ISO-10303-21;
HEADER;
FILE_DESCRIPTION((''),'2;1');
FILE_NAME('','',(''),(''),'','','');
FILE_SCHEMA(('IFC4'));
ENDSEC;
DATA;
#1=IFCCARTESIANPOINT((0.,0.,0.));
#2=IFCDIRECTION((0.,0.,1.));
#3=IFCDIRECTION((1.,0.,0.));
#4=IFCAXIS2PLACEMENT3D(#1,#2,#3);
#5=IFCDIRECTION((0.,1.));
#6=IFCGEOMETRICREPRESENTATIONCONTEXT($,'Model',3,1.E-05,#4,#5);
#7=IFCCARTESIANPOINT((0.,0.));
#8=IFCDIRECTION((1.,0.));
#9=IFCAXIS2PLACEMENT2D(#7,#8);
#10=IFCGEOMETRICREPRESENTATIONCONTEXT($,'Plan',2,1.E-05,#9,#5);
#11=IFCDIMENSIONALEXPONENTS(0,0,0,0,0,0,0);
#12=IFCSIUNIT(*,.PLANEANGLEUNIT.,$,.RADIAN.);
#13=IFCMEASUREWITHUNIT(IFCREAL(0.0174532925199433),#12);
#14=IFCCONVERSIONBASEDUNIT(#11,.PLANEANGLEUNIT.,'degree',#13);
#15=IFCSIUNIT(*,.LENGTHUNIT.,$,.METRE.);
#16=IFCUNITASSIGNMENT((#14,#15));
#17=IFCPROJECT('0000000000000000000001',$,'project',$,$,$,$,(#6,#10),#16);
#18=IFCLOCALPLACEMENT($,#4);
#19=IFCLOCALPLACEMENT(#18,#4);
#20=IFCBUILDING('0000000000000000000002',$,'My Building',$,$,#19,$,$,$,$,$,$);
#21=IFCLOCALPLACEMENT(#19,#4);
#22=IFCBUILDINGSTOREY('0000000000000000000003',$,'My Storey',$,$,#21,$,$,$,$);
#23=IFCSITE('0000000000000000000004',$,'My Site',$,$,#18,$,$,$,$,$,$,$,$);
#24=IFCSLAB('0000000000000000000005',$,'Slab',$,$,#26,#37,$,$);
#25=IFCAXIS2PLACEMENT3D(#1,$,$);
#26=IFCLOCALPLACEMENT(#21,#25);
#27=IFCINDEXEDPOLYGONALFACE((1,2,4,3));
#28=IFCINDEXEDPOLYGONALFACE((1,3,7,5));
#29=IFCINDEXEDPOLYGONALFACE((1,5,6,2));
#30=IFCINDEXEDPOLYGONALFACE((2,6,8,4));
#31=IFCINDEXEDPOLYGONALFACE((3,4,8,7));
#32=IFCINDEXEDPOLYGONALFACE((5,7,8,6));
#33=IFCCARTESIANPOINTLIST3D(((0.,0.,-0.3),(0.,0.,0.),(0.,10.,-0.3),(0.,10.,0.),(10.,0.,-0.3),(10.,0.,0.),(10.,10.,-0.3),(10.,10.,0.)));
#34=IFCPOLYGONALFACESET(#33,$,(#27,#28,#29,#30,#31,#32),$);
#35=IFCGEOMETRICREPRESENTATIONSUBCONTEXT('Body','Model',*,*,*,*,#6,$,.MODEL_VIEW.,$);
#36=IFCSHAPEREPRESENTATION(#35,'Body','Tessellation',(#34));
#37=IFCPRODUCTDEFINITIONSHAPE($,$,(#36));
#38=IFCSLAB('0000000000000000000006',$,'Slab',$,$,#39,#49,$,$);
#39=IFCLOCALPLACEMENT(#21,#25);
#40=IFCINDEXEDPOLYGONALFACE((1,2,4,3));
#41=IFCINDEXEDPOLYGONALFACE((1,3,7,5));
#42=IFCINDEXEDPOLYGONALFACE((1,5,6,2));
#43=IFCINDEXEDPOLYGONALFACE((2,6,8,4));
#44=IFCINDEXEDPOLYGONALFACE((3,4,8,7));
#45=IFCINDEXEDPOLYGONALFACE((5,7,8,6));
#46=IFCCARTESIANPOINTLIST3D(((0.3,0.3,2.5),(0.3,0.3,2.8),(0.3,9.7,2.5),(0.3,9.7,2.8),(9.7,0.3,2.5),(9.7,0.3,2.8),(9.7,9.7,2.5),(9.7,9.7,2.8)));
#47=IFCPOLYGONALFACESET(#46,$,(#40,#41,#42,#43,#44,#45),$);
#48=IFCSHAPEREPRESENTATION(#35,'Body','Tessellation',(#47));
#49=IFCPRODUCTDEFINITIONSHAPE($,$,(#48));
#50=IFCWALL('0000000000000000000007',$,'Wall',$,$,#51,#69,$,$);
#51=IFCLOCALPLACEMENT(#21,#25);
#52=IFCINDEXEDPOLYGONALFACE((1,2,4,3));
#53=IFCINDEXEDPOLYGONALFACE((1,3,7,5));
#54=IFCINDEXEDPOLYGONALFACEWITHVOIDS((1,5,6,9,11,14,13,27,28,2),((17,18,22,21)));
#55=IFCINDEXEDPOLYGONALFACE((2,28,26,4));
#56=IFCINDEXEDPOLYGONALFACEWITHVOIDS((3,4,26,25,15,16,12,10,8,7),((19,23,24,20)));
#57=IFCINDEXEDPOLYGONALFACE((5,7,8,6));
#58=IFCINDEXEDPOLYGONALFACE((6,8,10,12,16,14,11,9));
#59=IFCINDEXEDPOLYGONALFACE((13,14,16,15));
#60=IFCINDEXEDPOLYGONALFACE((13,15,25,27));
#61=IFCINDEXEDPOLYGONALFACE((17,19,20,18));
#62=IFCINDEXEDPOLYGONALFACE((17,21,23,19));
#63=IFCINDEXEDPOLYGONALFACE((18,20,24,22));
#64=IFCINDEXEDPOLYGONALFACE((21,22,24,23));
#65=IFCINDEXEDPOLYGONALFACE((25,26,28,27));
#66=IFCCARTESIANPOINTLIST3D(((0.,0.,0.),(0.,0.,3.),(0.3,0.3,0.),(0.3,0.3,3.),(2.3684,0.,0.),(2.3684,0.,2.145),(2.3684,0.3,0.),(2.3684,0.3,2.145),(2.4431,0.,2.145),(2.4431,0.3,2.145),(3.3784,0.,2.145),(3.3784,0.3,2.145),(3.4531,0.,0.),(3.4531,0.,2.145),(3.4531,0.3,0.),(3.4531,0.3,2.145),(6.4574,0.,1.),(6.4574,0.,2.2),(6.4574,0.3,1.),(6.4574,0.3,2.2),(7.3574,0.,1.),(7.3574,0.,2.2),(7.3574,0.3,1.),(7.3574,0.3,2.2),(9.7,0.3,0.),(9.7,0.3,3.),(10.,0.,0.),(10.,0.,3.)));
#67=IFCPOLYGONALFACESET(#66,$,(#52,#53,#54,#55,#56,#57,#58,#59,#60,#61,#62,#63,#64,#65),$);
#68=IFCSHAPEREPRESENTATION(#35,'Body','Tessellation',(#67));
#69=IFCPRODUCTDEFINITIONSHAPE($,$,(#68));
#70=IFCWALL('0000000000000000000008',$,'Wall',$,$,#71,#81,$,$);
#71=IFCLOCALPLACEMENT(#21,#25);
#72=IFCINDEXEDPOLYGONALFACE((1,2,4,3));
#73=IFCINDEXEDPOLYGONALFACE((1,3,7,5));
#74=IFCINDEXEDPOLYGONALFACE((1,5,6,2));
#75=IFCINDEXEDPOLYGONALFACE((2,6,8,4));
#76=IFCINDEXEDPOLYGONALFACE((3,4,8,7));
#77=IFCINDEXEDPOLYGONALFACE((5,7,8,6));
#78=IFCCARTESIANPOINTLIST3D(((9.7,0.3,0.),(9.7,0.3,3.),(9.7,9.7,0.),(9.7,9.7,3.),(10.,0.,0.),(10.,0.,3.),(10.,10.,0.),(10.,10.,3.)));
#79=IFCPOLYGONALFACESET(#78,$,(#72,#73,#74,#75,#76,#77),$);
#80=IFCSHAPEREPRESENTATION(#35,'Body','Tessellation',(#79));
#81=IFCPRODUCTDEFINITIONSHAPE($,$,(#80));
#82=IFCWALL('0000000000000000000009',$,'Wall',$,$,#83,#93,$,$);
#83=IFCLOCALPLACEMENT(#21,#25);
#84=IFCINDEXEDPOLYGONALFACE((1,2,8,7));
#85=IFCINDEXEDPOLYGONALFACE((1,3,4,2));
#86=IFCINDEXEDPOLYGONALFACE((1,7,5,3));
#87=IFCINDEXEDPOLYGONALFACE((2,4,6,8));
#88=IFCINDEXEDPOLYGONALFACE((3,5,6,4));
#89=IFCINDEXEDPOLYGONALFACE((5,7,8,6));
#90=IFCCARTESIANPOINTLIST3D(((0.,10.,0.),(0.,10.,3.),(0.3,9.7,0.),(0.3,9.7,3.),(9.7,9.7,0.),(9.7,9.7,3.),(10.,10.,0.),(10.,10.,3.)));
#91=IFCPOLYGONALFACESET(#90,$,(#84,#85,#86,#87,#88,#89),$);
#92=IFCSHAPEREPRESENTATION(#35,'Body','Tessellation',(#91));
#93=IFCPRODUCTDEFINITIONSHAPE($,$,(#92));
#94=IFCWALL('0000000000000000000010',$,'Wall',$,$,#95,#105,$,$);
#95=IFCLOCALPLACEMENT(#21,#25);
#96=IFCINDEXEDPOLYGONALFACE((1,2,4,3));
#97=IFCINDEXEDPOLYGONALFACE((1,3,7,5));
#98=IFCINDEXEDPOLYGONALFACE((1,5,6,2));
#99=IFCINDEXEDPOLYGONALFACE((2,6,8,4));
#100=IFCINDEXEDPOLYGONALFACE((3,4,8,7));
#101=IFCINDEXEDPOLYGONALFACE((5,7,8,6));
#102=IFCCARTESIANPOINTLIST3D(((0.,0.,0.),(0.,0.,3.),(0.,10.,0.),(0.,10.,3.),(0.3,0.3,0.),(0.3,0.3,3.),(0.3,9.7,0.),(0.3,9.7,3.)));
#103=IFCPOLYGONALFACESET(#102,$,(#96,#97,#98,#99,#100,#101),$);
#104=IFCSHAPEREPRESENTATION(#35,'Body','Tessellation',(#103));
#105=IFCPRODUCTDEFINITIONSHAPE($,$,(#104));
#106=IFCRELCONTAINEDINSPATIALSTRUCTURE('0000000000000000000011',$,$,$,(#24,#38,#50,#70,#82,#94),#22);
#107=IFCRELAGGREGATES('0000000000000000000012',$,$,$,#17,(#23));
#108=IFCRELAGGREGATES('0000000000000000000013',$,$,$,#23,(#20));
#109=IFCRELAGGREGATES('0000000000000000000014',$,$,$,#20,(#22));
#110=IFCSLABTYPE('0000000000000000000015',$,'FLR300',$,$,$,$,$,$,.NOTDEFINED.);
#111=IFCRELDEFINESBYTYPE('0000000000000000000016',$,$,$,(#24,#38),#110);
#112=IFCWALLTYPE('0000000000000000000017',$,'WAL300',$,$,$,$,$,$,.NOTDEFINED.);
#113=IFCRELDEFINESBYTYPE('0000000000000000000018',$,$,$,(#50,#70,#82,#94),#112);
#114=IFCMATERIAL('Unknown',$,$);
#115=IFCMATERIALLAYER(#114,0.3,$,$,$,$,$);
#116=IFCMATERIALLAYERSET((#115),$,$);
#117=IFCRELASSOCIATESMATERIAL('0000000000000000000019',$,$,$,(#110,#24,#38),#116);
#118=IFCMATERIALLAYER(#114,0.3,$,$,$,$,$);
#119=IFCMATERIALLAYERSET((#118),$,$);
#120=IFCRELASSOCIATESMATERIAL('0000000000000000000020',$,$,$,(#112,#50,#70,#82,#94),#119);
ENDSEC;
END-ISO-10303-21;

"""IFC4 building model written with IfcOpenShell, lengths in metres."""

from ifc_helpers import new_model, entity, si_unit, converted_unit, direction, frame, origin_with_axes, origin_2d_with_axis, place, context, subcontext, project, spatial, line, indexed_curve, outline, extrude, source, transform, mapped, material, layer, layer_set, layer_usage, type_object, element, save


model = new_model("IFC4")

# Units and contexts
model_context = context("Model", 3, precision=1e-05, world=origin_with_axes(), true_north=direction((0.0, 1.0)))
plan_context = context("Plan", 2, precision=1e-05, world=origin_2d_with_axis(), true_north=direction((0.0, 1.0)))
body_context = subcontext(model_context, "Body", "Model", "MODEL_VIEW")
ifc_project = project(units=[converted_unit("PLANEANGLEUNIT", "degree", entity("IfcReal", 0.0174532925199433), si_unit("PLANEANGLEUNIT", "RADIAN"), dimensions=[0, 0, 0, 0, 0, 0, 0]), si_unit("LENGTHUNIT", "METRE")], contexts=[model_context, plan_context])

# Site, building, storey
site_placement = place(None, origin_with_axes())
site = spatial("IfcSite", under=ifc_project, at=site_placement, Name="My Site")
building_placement = place(site_placement, origin_with_axes())
building = spatial("IfcBuilding", under=site, at=building_placement, Name="My Building")
storey_placement = place(building_placement, origin_with_axes())
storey = spatial("IfcBuildingStorey", under=building, at=storey_placement, Name="My Storey")

# Slabs
ifc_material = material(Name="Unknown")
ifc_layer_1 = layer(ifc_material, 0.3)
ifc_layer_set_1 = layer_set([ifc_layer_1])
ifc_layer_usage_1 = layer_usage(ifc_layer_set_1, "AXIS3", "POSITIVE", -0.3)
slab_type = type_object("IfcSlabType", Name="FLR300", PredefinedType="NOTDEFINED", material=ifc_layer_set_1)
slab_1_placement = place(storey_placement, origin_with_axes())
element("IfcSlab", 1, at=slab_1_placement, inside=storey, type_object=slab_type, material=ifc_layer_usage_1, Name="Slab", context=body_context, shape_type="SweptSolid", body=[
    extrude(outline(indexed_curve([(0.0, 0.0), (10.0, 0.0), (10.0, 10.0), (0.0, 10.0), (0.0, 0.0)])), frame((0.0, 0.0, -0.3), z_axis=(0.0, 0.0, 1.0), x_axis=(1.0, 0.0, 0.0)), (0.0, 0.0, 1.0), 0.3),
])
ifc_layer_usage_2 = layer_usage(ifc_layer_set_1, "AXIS3", "POSITIVE", -0.3)
slab_2_placement = place(storey_placement, frame((0.3, 0.3, 2.8), z_axis=(0.0, 0.0, 1.0), x_axis=(1.0, 0.0, 0.0)))
element("IfcSlab", 2, at=slab_2_placement, inside=storey, type_object=slab_type, material=ifc_layer_usage_2, Name="Slab", context=body_context, shape_type="SweptSolid", body=[
    extrude(outline(indexed_curve([(0.0, 0.0), (9.4, 0.0), (9.4, 9.4), (0.0, 9.4), (0.0, 0.0)])), frame((0.0, 0.0, -0.3), z_axis=(0.0, 0.0, 1.0), x_axis=(1.0, 0.0, 0.0)), (0.0, 0.0, 1.0), 0.3),
])

# Wall, openings
ifc_layer_2 = layer(ifc_material, 0.3)
ifc_layer_set_2 = layer_set([ifc_layer_2])
ifc_layer_usage_3 = layer_usage(ifc_layer_set_2, "AXIS2", "POSITIVE", 0.0)
wall_type = type_object("IfcWallType", Name="WAL300", PredefinedType="NOTDEFINED", material=ifc_layer_set_2)
wall_1_placement = place(storey_placement, frame((0.0, 0.0, 0.0), z_axis=(0.0, 0.0, 1.0), x_axis=(1.0, 0.0, 0.0)))
wall_1 = element("IfcWall", 3, at=wall_1_placement, inside=storey, type_object=wall_type, material=ifc_layer_usage_3, Name="Wall", context=body_context, shape_type="SweptSolid", body=[
    extrude(outline(indexed_curve([(0.0, 0.0), (0.3, 0.3), (9.7, 0.3), (10.0, 0.0)], segments=[line(1, 2, 3, 4, 1)])), origin_with_axes(), (0.0, 0.0, 1.0), 3.0),
])
shared_shape_1 = source(origin_with_axes(), body_context, "Body", "SweptSolid", [
    extrude(outline(indexed_curve([(0.0, 0.0), (1.01, 0.0), (1.01, 2.145), (0.0, 2.145)], segments=[line(1, 2, 3, 4, 1)])), frame((0.0, -0.6, 0.0), z_axis=(0.0, -1.0, 0.0), x_axis=(1.0, 0.0, 0.0)), (0.0, 0.0, -1.0), 1.2),
])
opening_1_placement = place(wall_1_placement, frame((2.3684, 0.0, 0.0), z_axis=(0.0, 0.0, 1.0), x_axis=(1.0, 0.0, 0.0)))
element("IfcOpeningElement", 4, at=opening_1_placement, cuts=wall_1, PredefinedType="OPENING", context=body_context, shape_type="MappedRepresentation", body=[
    mapped(shared_shape_1, transform((0.0, 0.0, 0.0), x_axis=(1.0, 0.0, 0.0), y_axis=(0.0, 1.0, 0.0), z_axis=(0.0, 0.0, 1.0), scale=1.0)),
])
opening_2_placement = place(wall_1_placement, frame((2.4431, 0.0, 0.0), z_axis=(0.0, 0.0, 1.0), x_axis=(1.0, 0.0, 0.0)))
element("IfcOpeningElement", 5, at=opening_2_placement, cuts=wall_1, PredefinedType="OPENING", context=body_context, shape_type="MappedRepresentation", body=[
    mapped(shared_shape_1, transform((0.0, 0.0, 0.0), x_axis=(1.0, 0.0, 0.0), y_axis=(0.0, 1.0, 0.0), z_axis=(0.0, 0.0, 1.0), scale=1.0)),
])
shared_shape_2 = source(origin_with_axes(), body_context, "Body", "SweptSolid", [
    extrude(outline(indexed_curve([(0.0, 0.0), (0.9, 0.0), (0.9, 1.2), (0.0, 1.2)], segments=[line(1, 2, 3, 4, 1)])), frame((0.0, -0.6, 0.0), z_axis=(0.0, -1.0, 0.0), x_axis=(1.0, 0.0, 0.0)), (0.0, 0.0, -1.0), 1.2),
])
opening_3_placement = place(wall_1_placement, frame((6.4574, 0.0, 1.0), z_axis=(0.0, 0.0, 1.0), x_axis=(1.0, 0.0, 0.0)))
element("IfcOpeningElement", 6, at=opening_3_placement, cuts=wall_1, PredefinedType="OPENING", context=body_context, shape_type="MappedRepresentation", body=[
    mapped(shared_shape_2, transform((0.0, 0.0, 0.0), x_axis=(1.0, 0.0, 0.0), y_axis=(0.0, 1.0, 0.0), z_axis=(0.0, 0.0, 1.0), scale=1.0)),
])

# Walls
ifc_layer_usage_4 = layer_usage(ifc_layer_set_2, "AXIS2", "POSITIVE", 0.0)
wall_2_placement = place(storey_placement, frame((10.0, 0.0, 0.0), z_axis=(0.0, 0.0, 1.0), x_axis=(0.0, 1.0, 0.0)))
element("IfcWall", 7, at=wall_2_placement, inside=storey, type_object=wall_type, material=ifc_layer_usage_4, Name="Wall", context=body_context, shape_type="SweptSolid", body=[
    extrude(outline(indexed_curve([(0.0, 0.0), (0.3, 0.3), (9.7, 0.3), (10.0, 0.0)], segments=[line(1, 2, 3, 4, 1)])), origin_with_axes(), (0.0, 0.0, 1.0), 3.0),
])
ifc_layer_usage_5 = layer_usage(ifc_layer_set_2, "AXIS2", "POSITIVE", 0.0)
wall_3_placement = place(storey_placement, frame((10.0, 10.0, 0.0), z_axis=(0.0, 0.0, 1.0), x_axis=(-1.0, 0.0, 0.0)))
element("IfcWall", 8, at=wall_3_placement, inside=storey, type_object=wall_type, material=ifc_layer_usage_5, Name="Wall", context=body_context, shape_type="SweptSolid", body=[
    extrude(outline(indexed_curve([(0.0, 0.0), (0.3, 0.3), (9.7, 0.3), (10.0, 0.0)], segments=[line(1, 2, 3, 4, 1)])), origin_with_axes(), (0.0, 0.0, 1.0), 3.0),
])
ifc_layer_usage_6 = layer_usage(ifc_layer_set_2, "AXIS2", "POSITIVE", 0.0)
wall_4_placement = place(storey_placement, frame((0.0, 10.0, 0.0), z_axis=(0.0, 0.0, 1.0), x_axis=(0.0, -1.0, 0.0)))
element("IfcWall", 9, at=wall_4_placement, inside=storey, type_object=wall_type, material=ifc_layer_usage_6, Name="Wall", context=body_context, shape_type="SweptSolid", body=[
    extrude(outline(indexed_curve([(0.0, 0.0), (0.3, 0.3), (9.7, 0.3), (10.0, 0.0)], segments=[line(1, 2, 3, 4, 1)])), origin_with_axes(), (0.0, 0.0, 1.0), 3.0),
])

save(model, "model.ifc")
